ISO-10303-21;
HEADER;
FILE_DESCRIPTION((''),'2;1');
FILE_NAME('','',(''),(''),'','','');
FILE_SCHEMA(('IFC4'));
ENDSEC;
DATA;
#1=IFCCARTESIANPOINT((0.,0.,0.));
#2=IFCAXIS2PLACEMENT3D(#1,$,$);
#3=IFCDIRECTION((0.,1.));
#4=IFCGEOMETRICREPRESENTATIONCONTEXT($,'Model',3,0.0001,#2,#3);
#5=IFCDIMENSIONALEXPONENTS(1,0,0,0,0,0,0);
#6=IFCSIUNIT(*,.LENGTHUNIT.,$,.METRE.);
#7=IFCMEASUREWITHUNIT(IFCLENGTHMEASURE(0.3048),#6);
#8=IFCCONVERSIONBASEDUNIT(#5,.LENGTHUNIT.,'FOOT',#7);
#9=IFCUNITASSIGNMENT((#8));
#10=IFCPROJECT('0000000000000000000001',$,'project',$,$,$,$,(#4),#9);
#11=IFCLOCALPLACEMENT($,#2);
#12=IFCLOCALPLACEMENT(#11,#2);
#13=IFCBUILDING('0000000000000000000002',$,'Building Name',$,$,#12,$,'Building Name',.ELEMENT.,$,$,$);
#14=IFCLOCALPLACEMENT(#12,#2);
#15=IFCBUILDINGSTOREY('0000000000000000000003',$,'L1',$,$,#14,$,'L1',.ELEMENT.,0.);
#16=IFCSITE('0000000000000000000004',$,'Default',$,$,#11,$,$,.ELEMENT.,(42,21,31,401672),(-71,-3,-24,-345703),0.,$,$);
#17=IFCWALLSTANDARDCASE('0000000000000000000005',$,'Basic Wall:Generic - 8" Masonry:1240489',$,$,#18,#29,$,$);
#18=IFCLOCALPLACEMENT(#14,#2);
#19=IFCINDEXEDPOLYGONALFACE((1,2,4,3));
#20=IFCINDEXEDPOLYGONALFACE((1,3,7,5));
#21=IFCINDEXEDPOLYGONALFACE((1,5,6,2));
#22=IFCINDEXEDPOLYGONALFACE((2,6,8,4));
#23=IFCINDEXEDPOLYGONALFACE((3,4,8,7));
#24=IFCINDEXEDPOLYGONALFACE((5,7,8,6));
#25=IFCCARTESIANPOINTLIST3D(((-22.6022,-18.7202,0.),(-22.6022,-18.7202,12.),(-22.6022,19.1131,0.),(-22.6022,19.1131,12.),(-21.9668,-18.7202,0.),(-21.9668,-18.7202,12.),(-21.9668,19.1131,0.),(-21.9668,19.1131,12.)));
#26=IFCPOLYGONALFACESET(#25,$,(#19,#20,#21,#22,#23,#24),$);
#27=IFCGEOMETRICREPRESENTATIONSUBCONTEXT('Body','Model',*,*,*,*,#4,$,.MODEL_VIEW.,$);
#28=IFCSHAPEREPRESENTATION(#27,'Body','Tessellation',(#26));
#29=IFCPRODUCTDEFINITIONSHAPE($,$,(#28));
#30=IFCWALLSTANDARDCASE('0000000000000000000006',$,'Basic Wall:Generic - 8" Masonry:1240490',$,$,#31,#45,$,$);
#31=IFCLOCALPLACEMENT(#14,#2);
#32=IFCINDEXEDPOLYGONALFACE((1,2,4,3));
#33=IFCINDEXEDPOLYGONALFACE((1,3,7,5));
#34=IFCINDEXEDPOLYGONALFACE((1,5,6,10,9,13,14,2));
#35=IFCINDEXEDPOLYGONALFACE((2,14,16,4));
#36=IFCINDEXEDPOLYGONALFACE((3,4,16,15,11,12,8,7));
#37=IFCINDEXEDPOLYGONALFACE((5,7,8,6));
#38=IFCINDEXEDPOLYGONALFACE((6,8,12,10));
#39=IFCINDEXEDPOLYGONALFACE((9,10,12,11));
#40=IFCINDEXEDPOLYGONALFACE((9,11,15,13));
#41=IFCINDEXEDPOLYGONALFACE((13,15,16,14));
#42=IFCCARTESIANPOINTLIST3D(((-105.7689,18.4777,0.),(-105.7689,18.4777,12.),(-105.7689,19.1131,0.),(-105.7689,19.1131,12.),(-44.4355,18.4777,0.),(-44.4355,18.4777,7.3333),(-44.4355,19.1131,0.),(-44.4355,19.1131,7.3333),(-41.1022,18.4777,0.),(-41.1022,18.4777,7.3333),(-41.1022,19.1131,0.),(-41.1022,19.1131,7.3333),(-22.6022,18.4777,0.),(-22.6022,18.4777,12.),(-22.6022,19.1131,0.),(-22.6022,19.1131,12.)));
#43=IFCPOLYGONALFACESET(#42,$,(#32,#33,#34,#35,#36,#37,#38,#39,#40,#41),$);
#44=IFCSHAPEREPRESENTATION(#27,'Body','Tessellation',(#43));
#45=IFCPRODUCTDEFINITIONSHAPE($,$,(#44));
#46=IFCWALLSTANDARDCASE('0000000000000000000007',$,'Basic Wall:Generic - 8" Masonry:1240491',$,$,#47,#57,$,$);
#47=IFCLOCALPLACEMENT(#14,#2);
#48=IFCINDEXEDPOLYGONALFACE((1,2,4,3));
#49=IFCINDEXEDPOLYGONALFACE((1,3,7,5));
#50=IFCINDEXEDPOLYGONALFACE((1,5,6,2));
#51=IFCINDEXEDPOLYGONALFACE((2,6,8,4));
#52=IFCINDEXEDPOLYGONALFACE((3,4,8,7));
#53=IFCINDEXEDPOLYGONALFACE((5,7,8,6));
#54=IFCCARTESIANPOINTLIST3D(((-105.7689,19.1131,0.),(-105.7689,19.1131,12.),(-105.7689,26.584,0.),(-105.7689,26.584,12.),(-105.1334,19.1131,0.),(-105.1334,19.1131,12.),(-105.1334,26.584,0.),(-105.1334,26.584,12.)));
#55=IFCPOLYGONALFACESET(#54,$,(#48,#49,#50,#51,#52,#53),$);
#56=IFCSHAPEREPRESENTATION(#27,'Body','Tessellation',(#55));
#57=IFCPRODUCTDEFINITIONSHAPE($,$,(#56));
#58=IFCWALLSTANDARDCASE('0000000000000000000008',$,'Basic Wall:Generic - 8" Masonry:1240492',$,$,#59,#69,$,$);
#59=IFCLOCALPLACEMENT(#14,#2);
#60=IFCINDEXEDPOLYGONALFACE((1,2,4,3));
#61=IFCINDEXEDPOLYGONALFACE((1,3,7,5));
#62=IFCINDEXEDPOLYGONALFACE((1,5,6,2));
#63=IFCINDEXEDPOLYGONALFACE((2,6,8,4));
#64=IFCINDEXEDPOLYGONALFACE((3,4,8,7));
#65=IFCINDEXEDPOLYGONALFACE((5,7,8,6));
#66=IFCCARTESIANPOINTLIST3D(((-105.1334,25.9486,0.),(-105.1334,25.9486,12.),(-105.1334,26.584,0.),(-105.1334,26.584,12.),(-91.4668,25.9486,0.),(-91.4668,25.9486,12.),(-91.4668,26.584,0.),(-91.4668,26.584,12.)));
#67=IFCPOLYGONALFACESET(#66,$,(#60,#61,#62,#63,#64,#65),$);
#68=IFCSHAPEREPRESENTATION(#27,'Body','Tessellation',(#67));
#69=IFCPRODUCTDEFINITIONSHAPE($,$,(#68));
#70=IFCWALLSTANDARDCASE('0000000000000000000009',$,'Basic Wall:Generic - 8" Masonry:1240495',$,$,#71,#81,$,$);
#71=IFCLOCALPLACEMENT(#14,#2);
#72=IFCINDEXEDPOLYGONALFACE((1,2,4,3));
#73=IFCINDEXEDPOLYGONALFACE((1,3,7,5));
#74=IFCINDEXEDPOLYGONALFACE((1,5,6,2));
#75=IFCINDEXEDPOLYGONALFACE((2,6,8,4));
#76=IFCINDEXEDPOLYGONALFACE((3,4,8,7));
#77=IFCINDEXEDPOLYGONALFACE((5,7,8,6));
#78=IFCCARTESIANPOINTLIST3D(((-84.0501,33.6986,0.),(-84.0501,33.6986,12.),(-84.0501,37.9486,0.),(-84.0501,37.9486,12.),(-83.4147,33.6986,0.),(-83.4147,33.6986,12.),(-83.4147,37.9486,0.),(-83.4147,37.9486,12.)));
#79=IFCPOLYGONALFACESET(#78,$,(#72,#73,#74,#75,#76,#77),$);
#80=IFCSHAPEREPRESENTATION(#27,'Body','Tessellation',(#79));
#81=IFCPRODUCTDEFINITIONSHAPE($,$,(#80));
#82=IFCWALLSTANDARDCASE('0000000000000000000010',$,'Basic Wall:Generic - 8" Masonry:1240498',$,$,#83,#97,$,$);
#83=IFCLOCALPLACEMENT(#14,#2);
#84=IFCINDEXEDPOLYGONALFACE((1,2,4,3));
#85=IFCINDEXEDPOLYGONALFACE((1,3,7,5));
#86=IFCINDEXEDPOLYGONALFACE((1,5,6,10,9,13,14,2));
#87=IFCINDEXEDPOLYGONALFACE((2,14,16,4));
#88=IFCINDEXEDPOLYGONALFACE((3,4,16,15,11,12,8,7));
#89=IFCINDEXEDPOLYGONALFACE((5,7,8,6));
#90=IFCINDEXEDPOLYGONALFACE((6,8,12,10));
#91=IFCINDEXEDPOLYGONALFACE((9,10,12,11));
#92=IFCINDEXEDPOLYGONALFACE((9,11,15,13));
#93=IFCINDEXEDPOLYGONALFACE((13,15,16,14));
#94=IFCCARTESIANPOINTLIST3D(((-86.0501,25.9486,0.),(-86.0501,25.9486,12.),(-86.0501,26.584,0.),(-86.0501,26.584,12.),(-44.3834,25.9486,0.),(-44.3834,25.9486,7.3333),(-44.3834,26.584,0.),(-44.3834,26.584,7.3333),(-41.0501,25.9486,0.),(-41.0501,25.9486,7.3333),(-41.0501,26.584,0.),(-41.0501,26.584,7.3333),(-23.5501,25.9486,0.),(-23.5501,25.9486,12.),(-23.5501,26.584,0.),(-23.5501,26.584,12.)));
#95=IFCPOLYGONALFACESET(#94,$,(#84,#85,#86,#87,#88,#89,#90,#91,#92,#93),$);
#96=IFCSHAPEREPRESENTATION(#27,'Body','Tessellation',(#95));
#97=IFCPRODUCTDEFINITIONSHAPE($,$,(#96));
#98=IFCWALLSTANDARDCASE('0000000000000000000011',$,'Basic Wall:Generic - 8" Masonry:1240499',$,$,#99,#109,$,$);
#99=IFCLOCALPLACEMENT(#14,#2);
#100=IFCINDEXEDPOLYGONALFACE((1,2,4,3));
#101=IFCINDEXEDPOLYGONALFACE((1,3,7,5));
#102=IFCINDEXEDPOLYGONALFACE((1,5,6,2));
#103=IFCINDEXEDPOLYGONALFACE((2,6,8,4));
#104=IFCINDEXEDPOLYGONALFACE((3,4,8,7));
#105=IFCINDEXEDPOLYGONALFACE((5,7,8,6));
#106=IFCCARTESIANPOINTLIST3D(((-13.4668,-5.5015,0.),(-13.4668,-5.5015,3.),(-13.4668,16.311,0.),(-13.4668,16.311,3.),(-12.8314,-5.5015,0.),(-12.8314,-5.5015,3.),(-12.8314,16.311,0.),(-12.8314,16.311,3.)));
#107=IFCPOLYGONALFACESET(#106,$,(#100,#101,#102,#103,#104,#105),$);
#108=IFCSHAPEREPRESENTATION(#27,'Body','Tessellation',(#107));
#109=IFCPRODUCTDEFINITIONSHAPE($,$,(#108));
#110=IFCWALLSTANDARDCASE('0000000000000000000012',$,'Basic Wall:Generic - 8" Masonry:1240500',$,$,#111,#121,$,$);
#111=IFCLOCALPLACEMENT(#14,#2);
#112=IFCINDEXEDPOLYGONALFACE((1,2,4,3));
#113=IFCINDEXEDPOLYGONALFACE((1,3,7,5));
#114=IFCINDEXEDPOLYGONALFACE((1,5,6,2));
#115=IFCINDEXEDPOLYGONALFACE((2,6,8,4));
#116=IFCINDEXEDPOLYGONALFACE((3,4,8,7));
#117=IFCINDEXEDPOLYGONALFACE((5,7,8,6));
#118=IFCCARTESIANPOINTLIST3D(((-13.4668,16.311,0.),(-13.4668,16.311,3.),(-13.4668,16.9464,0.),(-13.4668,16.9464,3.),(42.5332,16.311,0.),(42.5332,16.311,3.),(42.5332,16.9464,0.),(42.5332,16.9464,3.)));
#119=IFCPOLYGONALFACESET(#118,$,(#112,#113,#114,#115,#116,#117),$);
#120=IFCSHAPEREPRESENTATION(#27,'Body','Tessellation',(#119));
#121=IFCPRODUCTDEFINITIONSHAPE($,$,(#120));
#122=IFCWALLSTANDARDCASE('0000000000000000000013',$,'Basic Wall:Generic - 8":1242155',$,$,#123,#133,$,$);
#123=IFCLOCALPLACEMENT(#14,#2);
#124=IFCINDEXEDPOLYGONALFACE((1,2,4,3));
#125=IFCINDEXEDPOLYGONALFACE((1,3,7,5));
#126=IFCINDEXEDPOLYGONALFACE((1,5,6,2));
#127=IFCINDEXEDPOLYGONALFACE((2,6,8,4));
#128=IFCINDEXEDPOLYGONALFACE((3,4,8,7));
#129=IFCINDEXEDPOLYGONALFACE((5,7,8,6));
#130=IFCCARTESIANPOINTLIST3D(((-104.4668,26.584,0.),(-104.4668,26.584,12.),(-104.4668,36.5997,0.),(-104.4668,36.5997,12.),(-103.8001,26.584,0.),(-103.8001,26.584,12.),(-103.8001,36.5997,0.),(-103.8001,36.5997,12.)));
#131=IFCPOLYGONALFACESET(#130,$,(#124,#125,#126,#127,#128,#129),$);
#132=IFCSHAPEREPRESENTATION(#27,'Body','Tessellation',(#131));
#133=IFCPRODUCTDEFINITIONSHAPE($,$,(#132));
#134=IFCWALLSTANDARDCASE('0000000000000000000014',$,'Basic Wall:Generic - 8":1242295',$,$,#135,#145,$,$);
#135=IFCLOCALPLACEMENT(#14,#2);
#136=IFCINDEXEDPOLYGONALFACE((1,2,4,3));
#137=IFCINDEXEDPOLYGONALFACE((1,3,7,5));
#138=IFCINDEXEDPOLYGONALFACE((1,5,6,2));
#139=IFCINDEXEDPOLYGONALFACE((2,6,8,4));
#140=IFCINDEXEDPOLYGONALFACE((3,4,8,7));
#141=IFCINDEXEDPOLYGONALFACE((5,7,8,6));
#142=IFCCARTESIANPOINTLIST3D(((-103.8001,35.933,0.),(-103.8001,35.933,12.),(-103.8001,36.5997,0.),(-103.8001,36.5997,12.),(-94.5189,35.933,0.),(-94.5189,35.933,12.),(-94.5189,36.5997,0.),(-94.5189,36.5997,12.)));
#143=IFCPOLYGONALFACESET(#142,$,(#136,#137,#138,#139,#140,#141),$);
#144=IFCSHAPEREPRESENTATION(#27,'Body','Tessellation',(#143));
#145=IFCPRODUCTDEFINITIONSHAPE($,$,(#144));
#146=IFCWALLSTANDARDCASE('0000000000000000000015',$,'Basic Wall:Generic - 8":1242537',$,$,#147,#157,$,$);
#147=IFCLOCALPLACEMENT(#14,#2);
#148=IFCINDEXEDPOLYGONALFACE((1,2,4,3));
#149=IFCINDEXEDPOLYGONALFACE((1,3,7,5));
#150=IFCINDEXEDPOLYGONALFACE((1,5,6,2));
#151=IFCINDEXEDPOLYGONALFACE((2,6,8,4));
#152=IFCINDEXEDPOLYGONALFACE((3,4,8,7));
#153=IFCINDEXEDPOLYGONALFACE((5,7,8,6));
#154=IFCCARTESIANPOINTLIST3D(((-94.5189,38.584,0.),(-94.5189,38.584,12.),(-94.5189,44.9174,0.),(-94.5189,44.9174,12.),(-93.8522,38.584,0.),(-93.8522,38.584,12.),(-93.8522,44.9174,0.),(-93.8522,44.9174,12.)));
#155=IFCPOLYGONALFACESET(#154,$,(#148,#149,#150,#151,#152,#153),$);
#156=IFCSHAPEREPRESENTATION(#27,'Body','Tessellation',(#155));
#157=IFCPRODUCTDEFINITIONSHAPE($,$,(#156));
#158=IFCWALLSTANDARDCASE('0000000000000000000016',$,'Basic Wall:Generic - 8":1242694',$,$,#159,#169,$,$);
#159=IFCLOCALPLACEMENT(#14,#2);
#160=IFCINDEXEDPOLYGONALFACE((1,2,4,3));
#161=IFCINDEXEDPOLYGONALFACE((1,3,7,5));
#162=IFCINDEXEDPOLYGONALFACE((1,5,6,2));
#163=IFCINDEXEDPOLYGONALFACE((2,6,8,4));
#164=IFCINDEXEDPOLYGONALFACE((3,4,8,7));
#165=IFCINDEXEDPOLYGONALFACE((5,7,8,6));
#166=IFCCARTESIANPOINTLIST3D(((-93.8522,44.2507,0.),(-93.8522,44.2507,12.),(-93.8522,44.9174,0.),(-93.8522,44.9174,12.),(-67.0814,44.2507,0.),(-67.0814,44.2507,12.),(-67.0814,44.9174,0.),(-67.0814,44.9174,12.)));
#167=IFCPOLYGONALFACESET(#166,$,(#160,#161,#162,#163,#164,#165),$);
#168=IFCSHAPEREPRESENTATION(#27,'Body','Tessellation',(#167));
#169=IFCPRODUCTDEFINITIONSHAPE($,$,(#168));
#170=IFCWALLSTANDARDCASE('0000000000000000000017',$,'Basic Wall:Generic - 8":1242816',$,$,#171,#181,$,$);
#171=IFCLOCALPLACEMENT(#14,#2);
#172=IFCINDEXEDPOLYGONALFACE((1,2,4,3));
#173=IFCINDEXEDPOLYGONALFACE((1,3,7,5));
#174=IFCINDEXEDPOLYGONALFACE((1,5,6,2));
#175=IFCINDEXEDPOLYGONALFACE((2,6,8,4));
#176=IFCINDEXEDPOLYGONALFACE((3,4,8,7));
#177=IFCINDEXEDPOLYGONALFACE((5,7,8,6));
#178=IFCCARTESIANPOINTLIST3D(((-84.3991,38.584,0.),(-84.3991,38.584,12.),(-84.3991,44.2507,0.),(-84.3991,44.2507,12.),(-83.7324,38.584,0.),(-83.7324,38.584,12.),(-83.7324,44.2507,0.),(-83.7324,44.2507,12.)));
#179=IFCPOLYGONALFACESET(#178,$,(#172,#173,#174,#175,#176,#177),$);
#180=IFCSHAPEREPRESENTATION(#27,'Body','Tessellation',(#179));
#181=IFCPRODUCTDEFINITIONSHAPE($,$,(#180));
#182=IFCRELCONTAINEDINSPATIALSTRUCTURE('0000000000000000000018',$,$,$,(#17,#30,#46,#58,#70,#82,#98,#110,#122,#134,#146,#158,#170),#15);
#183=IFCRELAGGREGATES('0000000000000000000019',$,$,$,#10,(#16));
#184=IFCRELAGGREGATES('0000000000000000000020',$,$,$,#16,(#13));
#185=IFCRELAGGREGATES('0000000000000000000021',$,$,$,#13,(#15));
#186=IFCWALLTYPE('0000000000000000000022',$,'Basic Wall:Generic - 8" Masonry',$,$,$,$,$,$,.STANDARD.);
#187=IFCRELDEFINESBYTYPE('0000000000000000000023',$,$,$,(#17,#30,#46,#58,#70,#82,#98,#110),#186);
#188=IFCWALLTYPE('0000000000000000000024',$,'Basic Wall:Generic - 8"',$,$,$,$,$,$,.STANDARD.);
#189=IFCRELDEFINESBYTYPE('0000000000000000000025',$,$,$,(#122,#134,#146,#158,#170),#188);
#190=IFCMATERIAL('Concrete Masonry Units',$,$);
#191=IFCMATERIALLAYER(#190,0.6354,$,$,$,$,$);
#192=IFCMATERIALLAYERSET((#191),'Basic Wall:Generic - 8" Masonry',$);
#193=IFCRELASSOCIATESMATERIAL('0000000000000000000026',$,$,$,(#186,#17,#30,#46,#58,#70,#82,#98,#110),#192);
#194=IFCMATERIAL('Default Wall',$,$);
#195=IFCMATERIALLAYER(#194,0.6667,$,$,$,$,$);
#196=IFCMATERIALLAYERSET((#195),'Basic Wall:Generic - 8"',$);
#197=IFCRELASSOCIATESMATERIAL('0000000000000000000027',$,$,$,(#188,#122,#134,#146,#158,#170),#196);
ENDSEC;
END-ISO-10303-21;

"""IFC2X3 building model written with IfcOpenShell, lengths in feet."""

from ifc_helpers import new_model, entity, si_unit, converted_unit, direction, frame, frame_2d, origin, place, context, subcontext, project, spatial, rectangle, extrude, material, layer, layer_set, layer_usage, type_object, element, save


model = new_model("IFC2X3")

# Units and contexts
model_context = context("Model", 3, precision=0.0001, world=origin(), true_north=direction((0.0, 1.0)))
body_context = subcontext(model_context, "Body", "Model", "MODEL_VIEW")
ifc_project = project(units=[converted_unit("LENGTHUNIT", "FOOT", entity("IfcLengthMeasure", 0.3048), si_unit("LENGTHUNIT", "METRE"), dimensions=[1, 0, 0, 0, 0, 0, 0])], contexts=[model_context])

# Site, building, storey
site_placement = place(None, origin())
site = spatial("IfcSite", under=ifc_project, at=site_placement, Name="Default", CompositionType="ELEMENT", RefLatitude=(42, 21, 31, 401672), RefLongitude=(-71, -3, -24, -345703), RefElevation=0.0)
building_placement = place(site_placement, origin())
building = spatial("IfcBuilding", under=site, at=building_placement, Name="Building Name", LongName="Building Name", CompositionType="ELEMENT")
storey_placement = place(building_placement, origin())
storey = spatial("IfcBuildingStorey", under=building, at=storey_placement, Name="L1", LongName="L1", CompositionType="ELEMENT", Elevation=0.0)

# Wall
ifc_material_1 = material(Name="Concrete Masonry Units")
ifc_layer_1 = layer(ifc_material_1, 0.6354)
ifc_layer_set_1 = layer_set([ifc_layer_1], Name="Basic Wall:Generic - 8\" Masonry")
ifc_layer_usage_1 = layer_usage(ifc_layer_set_1, "AXIS2", "NEGATIVE", 0.3177)
wall_type_1 = type_object("IfcWallType", Name="Basic Wall:Generic - 8\" Masonry", PredefinedType="STANDARD", material=ifc_layer_set_1)
wall_1_placement = place(storey_placement, frame((-22.2845, 19.1131, 0.0), z_axis=(0.0, 0.0, 1.0), x_axis=(0.0, -1.0, 0.0)))
element("IfcWallStandardCase", 1, at=wall_1_placement, inside=storey, type_object=wall_type_1, material=ifc_layer_usage_1, Name="Basic Wall:Generic - 8\" Masonry:1240489", context=body_context, shape_type="SweptSolid", body=[
    extrude(rectangle(XDim=37.8333, YDim=0.6354, at=frame_2d((18.9167, 0.0), x_axis=(-1.0, 0.0))), origin(), (0.0, 0.0, 1.0), 12.0),
])

# Wall, opening
ifc_layer_usage_2 = layer_usage(ifc_layer_set_1, "AXIS2", "NEGATIVE", 0.3177)
wall_2_placement = place(storey_placement, frame((-22.6022, 18.7954, 0.0), z_axis=(0.0, 0.0, 1.0), x_axis=(-1.0, 0.0, 0.0)))
wall_2 = element("IfcWallStandardCase", 2, at=wall_2_placement, inside=storey, type_object=wall_type_1, material=ifc_layer_usage_2, Name="Basic Wall:Generic - 8\" Masonry:1240490", context=body_context, shape_type="SweptSolid", body=[
    extrude(rectangle(XDim=83.1667, YDim=0.6354, at=frame_2d((41.5833, 0.0), x_axis=(1.0, 0.0))), origin(), (0.0, 0.0, 1.0), 12.0),
])
opening_1_placement = place(wall_2_placement, frame((18.5, -0.3177, 0.0)))
element("IfcOpeningElement", 3, at=opening_1_placement, cuts=wall_2, ObjectType="Opening", context=body_context, shape_type="SweptSolid", body=[
    extrude(rectangle(XDim=7.3333, YDim=3.3333, at=frame_2d((3.6667, 1.6667), x_axis=(1.0, 0.0))), frame((0.0, 0.0, 0.0), z_axis=(0.0, 1.0, 0.0), x_axis=(0.0, 0.0, 1.0)), (0.0, 0.0, 1.0), 0.6354),
])

# Walls
ifc_layer_usage_3 = layer_usage(ifc_layer_set_1, "AXIS2", "NEGATIVE", 0.3177)
wall_3_placement = place(storey_placement, frame((-105.4511, 19.1131, 0.0), z_axis=(0.0, 0.0, 1.0), x_axis=(0.0, 1.0, 0.0)))
element("IfcWallStandardCase", 4, at=wall_3_placement, inside=storey, type_object=wall_type_1, material=ifc_layer_usage_3, Name="Basic Wall:Generic - 8\" Masonry:1240491", context=body_context, shape_type="SweptSolid", body=[
    extrude(rectangle(XDim=7.4709, YDim=0.6354, at=frame_2d((3.7355, 0.0), x_axis=(-1.0, 0.0))), origin(), (0.0, 0.0, 1.0), 12.0),
])
ifc_layer_usage_4 = layer_usage(ifc_layer_set_1, "AXIS2", "NEGATIVE", 0.3177)
wall_4_placement = place(storey_placement, frame((-105.1334, 26.2663, 0.0)))
element("IfcWallStandardCase", 5, at=wall_4_placement, inside=storey, type_object=wall_type_1, material=ifc_layer_usage_4, Name="Basic Wall:Generic - 8\" Masonry:1240492", context=body_context, shape_type="SweptSolid", body=[
    extrude(rectangle(XDim=13.6667, YDim=0.6354, at=frame_2d((6.8333, 0.0), x_axis=(-1.0, 0.0))), origin(), (0.0, 0.0, 1.0), 12.0),
])

# Wall
ifc_layer_usage_5 = layer_usage(ifc_layer_set_1, "AXIS2", "NEGATIVE", 0.3177)
wall_5_placement = place(storey_placement, frame((-83.7324, 37.9486, 0.0), z_axis=(0.0, 0.0, 1.0), x_axis=(0.0, -1.0, 0.0)))
element("IfcWallStandardCase", 6, at=wall_5_placement, inside=storey, type_object=wall_type_1, material=ifc_layer_usage_5, Name="Basic Wall:Generic - 8\" Masonry:1240495", context=body_context, shape_type="SweptSolid", body=[
    extrude(rectangle(XDim=4.25, YDim=0.6354, at=frame_2d((2.125, 0.0), x_axis=(-1.0, 0.0))), origin(), (0.0, 0.0, 1.0), 12.0),
])

# Wall, opening
ifc_layer_usage_6 = layer_usage(ifc_layer_set_1, "AXIS2", "NEGATIVE", 0.3177)
wall_6_placement = place(storey_placement, frame((-23.5501, 26.2663, 0.0), z_axis=(0.0, 0.0, 1.0), x_axis=(-1.0, 0.0, 0.0)))
wall_6 = element("IfcWallStandardCase", 7, at=wall_6_placement, inside=storey, type_object=wall_type_1, material=ifc_layer_usage_6, Name="Basic Wall:Generic - 8\" Masonry:1240498", context=body_context, shape_type="SweptSolid", body=[
    extrude(rectangle(XDim=62.5, YDim=0.6354, at=frame_2d((31.25, 0.0), x_axis=(1.0, 0.0))), origin(), (0.0, 0.0, 1.0), 12.0),
])
opening_2_placement = place(wall_6_placement, frame((20.8333, 0.3177, 0.0)))
element("IfcOpeningElement", 8, at=opening_2_placement, cuts=wall_6, ObjectType="Opening", context=body_context, shape_type="SweptSolid", body=[
    extrude(rectangle(XDim=7.3333, YDim=3.3333, at=frame_2d((3.6667, 1.6667), x_axis=(1.0, 0.0))), frame((0.0, 0.0, 0.0), z_axis=(0.0, -1.0, 0.0), x_axis=(0.0, 0.0, 1.0)), (0.0, 0.0, 1.0), 0.6354),
])

# Walls
ifc_layer_usage_7 = layer_usage(ifc_layer_set_1, "AXIS2", "NEGATIVE", 0.3177)
wall_7_placement = place(storey_placement, frame((-13.1491, -5.5015, 0.0), z_axis=(0.0, 0.0, 1.0), x_axis=(0.0, 1.0, 0.0)))
element("IfcWallStandardCase", 9, at=wall_7_placement, inside=storey, type_object=wall_type_1, material=ifc_layer_usage_7, Name="Basic Wall:Generic - 8\" Masonry:1240499", context=body_context, shape_type="SweptSolid", body=[
    extrude(rectangle(XDim=21.8125, YDim=0.6354, at=frame_2d((10.9063, 0.0), x_axis=(-1.0, 0.0))), origin(), (0.0, 0.0, 1.0), 3.0),
])
ifc_layer_usage_8 = layer_usage(ifc_layer_set_1, "AXIS2", "NEGATIVE", 0.3177)
wall_8_placement = place(storey_placement, frame((-13.4668, 16.6287, 0.0)))
element("IfcWallStandardCase", 10, at=wall_8_placement, inside=storey, type_object=wall_type_1, material=ifc_layer_usage_8, Name="Basic Wall:Generic - 8\" Masonry:1240500", context=body_context, shape_type="SweptSolid", body=[
    extrude(rectangle(XDim=56.0, YDim=0.6354, at=frame_2d((28.0, 0.0), x_axis=(-1.0, 0.0))), origin(), (0.0, 0.0, 1.0), 3.0),
])
ifc_material_2 = material(Name="Default Wall")
ifc_layer_2 = layer(ifc_material_2, 0.6667)
ifc_layer_set_2 = layer_set([ifc_layer_2], Name="Basic Wall:Generic - 8\"")
ifc_layer_usage_9 = layer_usage(ifc_layer_set_2, "AXIS2", "NEGATIVE", 0.3333)
wall_type_2 = type_object("IfcWallType", Name="Basic Wall:Generic - 8\"", PredefinedType="STANDARD", material=ifc_layer_set_2)
wall_9_placement = place(storey_placement, frame((-104.1334, 26.584, 0.0), z_axis=(0.0, 0.0, 1.0), x_axis=(0.0, 1.0, 0.0)))
element("IfcWallStandardCase", 11, at=wall_9_placement, inside=storey, type_object=wall_type_2, material=ifc_layer_usage_9, Name="Basic Wall:Generic - 8\":1242155", context=body_context, shape_type="SweptSolid", body=[
    extrude(rectangle(XDim=10.0156, YDim=0.6667, at=frame_2d((5.0078, 0.0), x_axis=(-1.0, 0.0))), origin(), (0.0, 0.0, 1.0), 12.0),
])
ifc_layer_usage_10 = layer_usage(ifc_layer_set_2, "AXIS2", "POSITIVE", -0.3333)
wall_10_placement = place(storey_placement, frame((-103.8001, 36.2663, 0.0)))
element("IfcWallStandardCase", 12, at=wall_10_placement, inside=storey, type_object=wall_type_2, material=ifc_layer_usage_10, Name="Basic Wall:Generic - 8\":1242295", context=body_context, shape_type="SweptSolid", body=[
    extrude(rectangle(XDim=9.2812, YDim=0.6667, at=frame_2d((4.6406, 0.0), x_axis=(-1.0, 0.0))), origin(), (0.0, 0.0, 1.0), 12.0),
])
ifc_layer_usage_11 = layer_usage(ifc_layer_set_2, "AXIS2", "NEGATIVE", 0.3333)
wall_11_placement = place(storey_placement, frame((-94.1855, 38.584, 0.0), z_axis=(0.0, 0.0, 1.0), x_axis=(0.0, 1.0, 0.0)))
element("IfcWallStandardCase", 13, at=wall_11_placement, inside=storey, type_object=wall_type_2, material=ifc_layer_usage_11, Name="Basic Wall:Generic - 8\":1242537", context=body_context, shape_type="SweptSolid", body=[
    extrude(rectangle(XDim=6.3333, YDim=0.6667, at=frame_2d((3.1667, 0.0), x_axis=(-1.0, 0.0))), origin(), (0.0, 0.0, 1.0), 12.0),
])
ifc_layer_usage_12 = layer_usage(ifc_layer_set_2, "AXIS2", "POSITIVE", -0.3333)
wall_12_placement = place(storey_placement, frame((-93.8522, 44.584, 0.0)))
element("IfcWallStandardCase", 14, at=wall_12_placement, inside=storey, type_object=wall_type_2, material=ifc_layer_usage_12, Name="Basic Wall:Generic - 8\":1242694", context=body_context, shape_type="SweptSolid", body=[
    extrude(rectangle(XDim=26.7708, YDim=0.6667, at=frame_2d((13.3854, 0.0), x_axis=(-1.0, 0.0))), origin(), (0.0, 0.0, 1.0), 12.0),
])
ifc_layer_usage_13 = layer_usage(ifc_layer_set_2, "AXIS2", "NEGATIVE", 0.3333)
wall_13_placement = place(storey_placement, frame((-84.0657, 44.2507, 0.0), z_axis=(0.0, 0.0, 1.0), x_axis=(0.0, -1.0, 0.0)))
element("IfcWallStandardCase", 15, at=wall_13_placement, inside=storey, type_object=wall_type_2, material=ifc_layer_usage_13, Name="Basic Wall:Generic - 8\":1242816", context=body_context, shape_type="SweptSolid", body=[
    extrude(rectangle(XDim=5.6667, YDim=0.6667, at=frame_2d((2.8333, 0.0), x_axis=(-1.0, 0.0))), origin(), (0.0, 0.0, 1.0), 12.0),
])

save(model, "model.ifc")
